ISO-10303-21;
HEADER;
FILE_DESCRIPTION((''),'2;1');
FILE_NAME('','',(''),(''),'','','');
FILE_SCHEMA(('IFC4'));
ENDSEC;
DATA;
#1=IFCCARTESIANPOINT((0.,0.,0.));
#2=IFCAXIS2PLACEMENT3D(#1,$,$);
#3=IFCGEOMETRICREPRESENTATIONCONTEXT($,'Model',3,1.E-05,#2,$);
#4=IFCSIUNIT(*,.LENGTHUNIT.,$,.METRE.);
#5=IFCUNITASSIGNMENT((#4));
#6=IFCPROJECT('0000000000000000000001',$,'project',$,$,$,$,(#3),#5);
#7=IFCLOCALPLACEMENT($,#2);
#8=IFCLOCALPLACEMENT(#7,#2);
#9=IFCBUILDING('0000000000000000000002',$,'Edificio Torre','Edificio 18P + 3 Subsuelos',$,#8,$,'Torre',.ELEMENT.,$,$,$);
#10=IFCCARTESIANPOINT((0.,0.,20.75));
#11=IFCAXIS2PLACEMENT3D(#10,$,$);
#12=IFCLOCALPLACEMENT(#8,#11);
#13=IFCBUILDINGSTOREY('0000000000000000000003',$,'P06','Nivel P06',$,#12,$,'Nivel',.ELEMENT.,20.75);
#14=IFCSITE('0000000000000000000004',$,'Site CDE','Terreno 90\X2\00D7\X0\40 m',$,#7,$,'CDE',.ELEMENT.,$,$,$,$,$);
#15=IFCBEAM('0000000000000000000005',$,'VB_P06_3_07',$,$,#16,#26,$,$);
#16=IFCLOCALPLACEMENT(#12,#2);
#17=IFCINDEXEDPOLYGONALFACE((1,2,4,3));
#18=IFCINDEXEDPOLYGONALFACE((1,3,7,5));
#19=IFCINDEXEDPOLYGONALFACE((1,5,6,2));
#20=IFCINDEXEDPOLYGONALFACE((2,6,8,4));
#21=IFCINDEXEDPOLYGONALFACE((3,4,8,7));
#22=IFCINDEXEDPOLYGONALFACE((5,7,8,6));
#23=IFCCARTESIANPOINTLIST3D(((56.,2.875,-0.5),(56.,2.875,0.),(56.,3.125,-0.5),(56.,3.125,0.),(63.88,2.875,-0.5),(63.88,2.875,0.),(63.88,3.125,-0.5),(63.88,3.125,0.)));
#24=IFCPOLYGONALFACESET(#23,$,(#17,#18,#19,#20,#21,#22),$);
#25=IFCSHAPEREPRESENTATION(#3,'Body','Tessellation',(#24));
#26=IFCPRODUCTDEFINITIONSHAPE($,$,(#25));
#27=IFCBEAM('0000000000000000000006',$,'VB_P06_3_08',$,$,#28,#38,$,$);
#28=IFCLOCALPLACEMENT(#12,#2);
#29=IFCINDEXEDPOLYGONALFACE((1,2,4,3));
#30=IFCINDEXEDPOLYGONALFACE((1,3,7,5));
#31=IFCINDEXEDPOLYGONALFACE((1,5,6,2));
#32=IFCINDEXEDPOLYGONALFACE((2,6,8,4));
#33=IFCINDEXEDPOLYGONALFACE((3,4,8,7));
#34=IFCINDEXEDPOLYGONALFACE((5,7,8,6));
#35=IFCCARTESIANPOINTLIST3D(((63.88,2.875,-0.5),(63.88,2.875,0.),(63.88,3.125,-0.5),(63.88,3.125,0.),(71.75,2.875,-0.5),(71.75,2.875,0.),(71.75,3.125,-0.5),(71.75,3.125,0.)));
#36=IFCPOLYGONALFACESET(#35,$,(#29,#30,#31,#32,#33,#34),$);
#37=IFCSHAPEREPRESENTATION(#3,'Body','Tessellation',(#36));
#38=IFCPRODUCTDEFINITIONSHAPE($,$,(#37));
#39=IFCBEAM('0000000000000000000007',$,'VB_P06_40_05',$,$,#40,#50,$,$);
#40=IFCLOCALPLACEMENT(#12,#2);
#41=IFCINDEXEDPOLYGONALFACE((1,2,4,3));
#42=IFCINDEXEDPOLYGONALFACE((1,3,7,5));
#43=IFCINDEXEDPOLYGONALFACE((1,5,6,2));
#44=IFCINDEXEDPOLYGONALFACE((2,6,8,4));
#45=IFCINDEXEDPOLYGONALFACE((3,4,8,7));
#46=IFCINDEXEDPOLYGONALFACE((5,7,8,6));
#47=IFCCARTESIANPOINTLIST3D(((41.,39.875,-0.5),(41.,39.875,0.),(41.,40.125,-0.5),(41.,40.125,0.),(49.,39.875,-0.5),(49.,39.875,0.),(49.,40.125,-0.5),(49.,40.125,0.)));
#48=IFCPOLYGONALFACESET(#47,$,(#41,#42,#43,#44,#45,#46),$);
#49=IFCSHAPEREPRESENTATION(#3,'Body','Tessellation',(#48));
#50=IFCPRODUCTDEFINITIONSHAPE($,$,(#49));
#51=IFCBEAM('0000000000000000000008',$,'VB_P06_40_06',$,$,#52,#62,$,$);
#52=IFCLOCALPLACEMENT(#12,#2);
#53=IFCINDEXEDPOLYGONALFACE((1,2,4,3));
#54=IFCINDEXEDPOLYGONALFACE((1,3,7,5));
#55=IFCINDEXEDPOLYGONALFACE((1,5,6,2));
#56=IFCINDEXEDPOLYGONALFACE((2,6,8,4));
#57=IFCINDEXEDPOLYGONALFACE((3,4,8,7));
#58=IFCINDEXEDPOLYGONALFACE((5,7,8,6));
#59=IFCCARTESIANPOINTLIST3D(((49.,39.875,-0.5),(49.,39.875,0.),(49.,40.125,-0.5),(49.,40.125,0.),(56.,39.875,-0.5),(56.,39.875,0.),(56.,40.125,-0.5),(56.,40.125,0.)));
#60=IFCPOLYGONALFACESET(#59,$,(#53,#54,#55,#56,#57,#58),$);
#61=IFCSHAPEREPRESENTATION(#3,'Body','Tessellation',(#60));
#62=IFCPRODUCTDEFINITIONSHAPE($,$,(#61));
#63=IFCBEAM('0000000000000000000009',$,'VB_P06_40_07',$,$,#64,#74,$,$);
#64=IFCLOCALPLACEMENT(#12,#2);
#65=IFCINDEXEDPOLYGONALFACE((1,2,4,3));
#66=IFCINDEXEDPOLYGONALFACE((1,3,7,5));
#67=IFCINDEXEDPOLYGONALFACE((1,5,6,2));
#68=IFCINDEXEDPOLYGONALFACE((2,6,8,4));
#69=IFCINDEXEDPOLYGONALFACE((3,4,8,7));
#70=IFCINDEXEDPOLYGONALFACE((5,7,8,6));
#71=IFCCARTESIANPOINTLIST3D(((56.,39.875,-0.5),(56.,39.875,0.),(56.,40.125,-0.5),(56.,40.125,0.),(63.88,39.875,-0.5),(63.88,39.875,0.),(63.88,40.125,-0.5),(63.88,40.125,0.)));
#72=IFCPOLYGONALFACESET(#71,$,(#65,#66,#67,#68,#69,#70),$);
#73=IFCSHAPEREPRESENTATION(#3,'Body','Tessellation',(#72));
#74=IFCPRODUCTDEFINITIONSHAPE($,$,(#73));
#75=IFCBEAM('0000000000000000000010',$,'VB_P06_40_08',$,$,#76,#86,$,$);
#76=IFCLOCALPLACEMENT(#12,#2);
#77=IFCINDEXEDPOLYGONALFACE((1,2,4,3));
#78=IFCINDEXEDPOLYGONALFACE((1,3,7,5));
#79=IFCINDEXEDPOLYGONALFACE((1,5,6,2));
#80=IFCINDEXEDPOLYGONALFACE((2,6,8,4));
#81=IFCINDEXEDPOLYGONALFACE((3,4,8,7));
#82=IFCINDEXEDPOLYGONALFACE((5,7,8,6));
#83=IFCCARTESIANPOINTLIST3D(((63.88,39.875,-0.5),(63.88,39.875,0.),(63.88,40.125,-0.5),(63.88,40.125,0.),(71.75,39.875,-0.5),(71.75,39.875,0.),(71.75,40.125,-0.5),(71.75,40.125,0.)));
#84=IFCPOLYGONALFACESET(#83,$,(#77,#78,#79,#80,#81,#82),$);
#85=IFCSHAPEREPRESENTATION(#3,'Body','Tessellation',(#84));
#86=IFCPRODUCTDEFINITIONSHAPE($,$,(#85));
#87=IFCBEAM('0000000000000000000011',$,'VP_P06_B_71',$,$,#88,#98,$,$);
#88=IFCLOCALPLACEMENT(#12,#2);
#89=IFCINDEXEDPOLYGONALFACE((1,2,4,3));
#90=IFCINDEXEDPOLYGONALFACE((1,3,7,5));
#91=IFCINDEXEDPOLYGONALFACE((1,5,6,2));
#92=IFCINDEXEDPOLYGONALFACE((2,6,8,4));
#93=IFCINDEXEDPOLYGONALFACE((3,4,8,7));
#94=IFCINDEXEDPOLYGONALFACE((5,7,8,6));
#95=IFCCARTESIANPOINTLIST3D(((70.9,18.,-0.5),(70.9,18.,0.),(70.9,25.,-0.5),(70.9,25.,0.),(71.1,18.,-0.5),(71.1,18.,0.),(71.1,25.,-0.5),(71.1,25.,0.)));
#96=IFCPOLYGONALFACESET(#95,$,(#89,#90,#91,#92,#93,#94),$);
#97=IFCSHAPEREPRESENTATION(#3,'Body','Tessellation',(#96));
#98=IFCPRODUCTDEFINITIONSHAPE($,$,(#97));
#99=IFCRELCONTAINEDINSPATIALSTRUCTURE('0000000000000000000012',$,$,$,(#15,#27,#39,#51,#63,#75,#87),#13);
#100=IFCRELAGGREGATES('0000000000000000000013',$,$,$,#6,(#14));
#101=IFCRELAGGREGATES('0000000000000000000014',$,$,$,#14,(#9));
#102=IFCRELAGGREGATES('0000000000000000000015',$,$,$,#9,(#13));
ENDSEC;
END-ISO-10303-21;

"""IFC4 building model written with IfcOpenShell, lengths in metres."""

from ifc_helpers import new_model, si_unit, frame, origin, origin_2d, place, context, project, spatial, rectangle, extrude, element, save


model = new_model("IFC4")

# Units and contexts
model_context = context("Model", 3, precision=1e-05, world=origin())
ifc_project = project(units=[si_unit("LENGTHUNIT", "METRE")], contexts=[model_context])

# Site, building, storey
site_placement = place(None, origin())
site = spatial("IfcSite", under=ifc_project, at=site_placement, Name="Site CDE", Description="Terreno 90×40 m", LongName="CDE", CompositionType="ELEMENT")
building_placement = place(site_placement, origin())
building = spatial("IfcBuilding", under=site, at=building_placement, Name="Edificio Torre", Description="Edificio 18P + 3 Subsuelos", LongName="Torre", CompositionType="ELEMENT")
storey_placement = place(building_placement, frame((0.0, 0.0, 20.75)))
storey = spatial("IfcBuildingStorey", under=building, at=storey_placement, Name="P06", Description="Nivel P06", LongName="Nivel", CompositionType="ELEMENT", Elevation=20.75)

# Beams
beam_1_placement = place(storey_placement, frame((59.94, 3.0, -0.5)))
element("IfcBeam", 1, at=beam_1_placement, inside=storey, Name="VB_P06_3_07", context=model_context, shape_type="SweptSolid", body=[
    extrude(rectangle(XDim=7.88, YDim=0.25, at=origin_2d()), origin(), (0.0, 0.0, 1.0), 0.5),
])
beam_2_placement = place(storey_placement, frame((67.815, 3.0, -0.5)))
element("IfcBeam", 2, at=beam_2_placement, inside=storey, Name="VB_P06_3_08", context=model_context, shape_type="SweptSolid", body=[
    extrude(rectangle(XDim=7.87, YDim=0.25, at=origin_2d()), origin(), (0.0, 0.0, 1.0), 0.5),
])
beam_3_placement = place(storey_placement, frame((45.0, 40.0, -0.5)))
element("IfcBeam", 3, at=beam_3_placement, inside=storey, Name="VB_P06_40_05", context=model_context, shape_type="SweptSolid", body=[
    extrude(rectangle(XDim=8.0, YDim=0.25, at=origin_2d()), origin(), (0.0, 0.0, 1.0), 0.5),
])
beam_4_placement = place(storey_placement, frame((52.5, 40.0, -0.5)))
element("IfcBeam", 4, at=beam_4_placement, inside=storey, Name="VB_P06_40_06", context=model_context, shape_type="SweptSolid", body=[
    extrude(rectangle(XDim=7.0, YDim=0.25, at=origin_2d()), origin(), (0.0, 0.0, 1.0), 0.5),
])
beam_5_placement = place(storey_placement, frame((59.94, 40.0, -0.5)))
element("IfcBeam", 5, at=beam_5_placement, inside=storey, Name="VB_P06_40_07", context=model_context, shape_type="SweptSolid", body=[
    extrude(rectangle(XDim=7.88, YDim=0.25, at=origin_2d()), origin(), (0.0, 0.0, 1.0), 0.5),
])
beam_6_placement = place(storey_placement, frame((67.815, 40.0, -0.5)))
element("IfcBeam", 6, at=beam_6_placement, inside=storey, Name="VB_P06_40_08", context=model_context, shape_type="SweptSolid", body=[
    extrude(rectangle(XDim=7.87, YDim=0.25, at=origin_2d()), origin(), (0.0, 0.0, 1.0), 0.5),
])
beam_7_placement = place(storey_placement, frame((71.0, 21.5, -0.5)))
element("IfcBeam", 7, at=beam_7_placement, inside=storey, Name="VP_P06_B_71", context=model_context, shape_type="SweptSolid", body=[
    extrude(rectangle(XDim=0.2, YDim=7.0, at=origin_2d()), origin(), (0.0, 0.0, 1.0), 0.5),
])

save(model, "model.ifc")
